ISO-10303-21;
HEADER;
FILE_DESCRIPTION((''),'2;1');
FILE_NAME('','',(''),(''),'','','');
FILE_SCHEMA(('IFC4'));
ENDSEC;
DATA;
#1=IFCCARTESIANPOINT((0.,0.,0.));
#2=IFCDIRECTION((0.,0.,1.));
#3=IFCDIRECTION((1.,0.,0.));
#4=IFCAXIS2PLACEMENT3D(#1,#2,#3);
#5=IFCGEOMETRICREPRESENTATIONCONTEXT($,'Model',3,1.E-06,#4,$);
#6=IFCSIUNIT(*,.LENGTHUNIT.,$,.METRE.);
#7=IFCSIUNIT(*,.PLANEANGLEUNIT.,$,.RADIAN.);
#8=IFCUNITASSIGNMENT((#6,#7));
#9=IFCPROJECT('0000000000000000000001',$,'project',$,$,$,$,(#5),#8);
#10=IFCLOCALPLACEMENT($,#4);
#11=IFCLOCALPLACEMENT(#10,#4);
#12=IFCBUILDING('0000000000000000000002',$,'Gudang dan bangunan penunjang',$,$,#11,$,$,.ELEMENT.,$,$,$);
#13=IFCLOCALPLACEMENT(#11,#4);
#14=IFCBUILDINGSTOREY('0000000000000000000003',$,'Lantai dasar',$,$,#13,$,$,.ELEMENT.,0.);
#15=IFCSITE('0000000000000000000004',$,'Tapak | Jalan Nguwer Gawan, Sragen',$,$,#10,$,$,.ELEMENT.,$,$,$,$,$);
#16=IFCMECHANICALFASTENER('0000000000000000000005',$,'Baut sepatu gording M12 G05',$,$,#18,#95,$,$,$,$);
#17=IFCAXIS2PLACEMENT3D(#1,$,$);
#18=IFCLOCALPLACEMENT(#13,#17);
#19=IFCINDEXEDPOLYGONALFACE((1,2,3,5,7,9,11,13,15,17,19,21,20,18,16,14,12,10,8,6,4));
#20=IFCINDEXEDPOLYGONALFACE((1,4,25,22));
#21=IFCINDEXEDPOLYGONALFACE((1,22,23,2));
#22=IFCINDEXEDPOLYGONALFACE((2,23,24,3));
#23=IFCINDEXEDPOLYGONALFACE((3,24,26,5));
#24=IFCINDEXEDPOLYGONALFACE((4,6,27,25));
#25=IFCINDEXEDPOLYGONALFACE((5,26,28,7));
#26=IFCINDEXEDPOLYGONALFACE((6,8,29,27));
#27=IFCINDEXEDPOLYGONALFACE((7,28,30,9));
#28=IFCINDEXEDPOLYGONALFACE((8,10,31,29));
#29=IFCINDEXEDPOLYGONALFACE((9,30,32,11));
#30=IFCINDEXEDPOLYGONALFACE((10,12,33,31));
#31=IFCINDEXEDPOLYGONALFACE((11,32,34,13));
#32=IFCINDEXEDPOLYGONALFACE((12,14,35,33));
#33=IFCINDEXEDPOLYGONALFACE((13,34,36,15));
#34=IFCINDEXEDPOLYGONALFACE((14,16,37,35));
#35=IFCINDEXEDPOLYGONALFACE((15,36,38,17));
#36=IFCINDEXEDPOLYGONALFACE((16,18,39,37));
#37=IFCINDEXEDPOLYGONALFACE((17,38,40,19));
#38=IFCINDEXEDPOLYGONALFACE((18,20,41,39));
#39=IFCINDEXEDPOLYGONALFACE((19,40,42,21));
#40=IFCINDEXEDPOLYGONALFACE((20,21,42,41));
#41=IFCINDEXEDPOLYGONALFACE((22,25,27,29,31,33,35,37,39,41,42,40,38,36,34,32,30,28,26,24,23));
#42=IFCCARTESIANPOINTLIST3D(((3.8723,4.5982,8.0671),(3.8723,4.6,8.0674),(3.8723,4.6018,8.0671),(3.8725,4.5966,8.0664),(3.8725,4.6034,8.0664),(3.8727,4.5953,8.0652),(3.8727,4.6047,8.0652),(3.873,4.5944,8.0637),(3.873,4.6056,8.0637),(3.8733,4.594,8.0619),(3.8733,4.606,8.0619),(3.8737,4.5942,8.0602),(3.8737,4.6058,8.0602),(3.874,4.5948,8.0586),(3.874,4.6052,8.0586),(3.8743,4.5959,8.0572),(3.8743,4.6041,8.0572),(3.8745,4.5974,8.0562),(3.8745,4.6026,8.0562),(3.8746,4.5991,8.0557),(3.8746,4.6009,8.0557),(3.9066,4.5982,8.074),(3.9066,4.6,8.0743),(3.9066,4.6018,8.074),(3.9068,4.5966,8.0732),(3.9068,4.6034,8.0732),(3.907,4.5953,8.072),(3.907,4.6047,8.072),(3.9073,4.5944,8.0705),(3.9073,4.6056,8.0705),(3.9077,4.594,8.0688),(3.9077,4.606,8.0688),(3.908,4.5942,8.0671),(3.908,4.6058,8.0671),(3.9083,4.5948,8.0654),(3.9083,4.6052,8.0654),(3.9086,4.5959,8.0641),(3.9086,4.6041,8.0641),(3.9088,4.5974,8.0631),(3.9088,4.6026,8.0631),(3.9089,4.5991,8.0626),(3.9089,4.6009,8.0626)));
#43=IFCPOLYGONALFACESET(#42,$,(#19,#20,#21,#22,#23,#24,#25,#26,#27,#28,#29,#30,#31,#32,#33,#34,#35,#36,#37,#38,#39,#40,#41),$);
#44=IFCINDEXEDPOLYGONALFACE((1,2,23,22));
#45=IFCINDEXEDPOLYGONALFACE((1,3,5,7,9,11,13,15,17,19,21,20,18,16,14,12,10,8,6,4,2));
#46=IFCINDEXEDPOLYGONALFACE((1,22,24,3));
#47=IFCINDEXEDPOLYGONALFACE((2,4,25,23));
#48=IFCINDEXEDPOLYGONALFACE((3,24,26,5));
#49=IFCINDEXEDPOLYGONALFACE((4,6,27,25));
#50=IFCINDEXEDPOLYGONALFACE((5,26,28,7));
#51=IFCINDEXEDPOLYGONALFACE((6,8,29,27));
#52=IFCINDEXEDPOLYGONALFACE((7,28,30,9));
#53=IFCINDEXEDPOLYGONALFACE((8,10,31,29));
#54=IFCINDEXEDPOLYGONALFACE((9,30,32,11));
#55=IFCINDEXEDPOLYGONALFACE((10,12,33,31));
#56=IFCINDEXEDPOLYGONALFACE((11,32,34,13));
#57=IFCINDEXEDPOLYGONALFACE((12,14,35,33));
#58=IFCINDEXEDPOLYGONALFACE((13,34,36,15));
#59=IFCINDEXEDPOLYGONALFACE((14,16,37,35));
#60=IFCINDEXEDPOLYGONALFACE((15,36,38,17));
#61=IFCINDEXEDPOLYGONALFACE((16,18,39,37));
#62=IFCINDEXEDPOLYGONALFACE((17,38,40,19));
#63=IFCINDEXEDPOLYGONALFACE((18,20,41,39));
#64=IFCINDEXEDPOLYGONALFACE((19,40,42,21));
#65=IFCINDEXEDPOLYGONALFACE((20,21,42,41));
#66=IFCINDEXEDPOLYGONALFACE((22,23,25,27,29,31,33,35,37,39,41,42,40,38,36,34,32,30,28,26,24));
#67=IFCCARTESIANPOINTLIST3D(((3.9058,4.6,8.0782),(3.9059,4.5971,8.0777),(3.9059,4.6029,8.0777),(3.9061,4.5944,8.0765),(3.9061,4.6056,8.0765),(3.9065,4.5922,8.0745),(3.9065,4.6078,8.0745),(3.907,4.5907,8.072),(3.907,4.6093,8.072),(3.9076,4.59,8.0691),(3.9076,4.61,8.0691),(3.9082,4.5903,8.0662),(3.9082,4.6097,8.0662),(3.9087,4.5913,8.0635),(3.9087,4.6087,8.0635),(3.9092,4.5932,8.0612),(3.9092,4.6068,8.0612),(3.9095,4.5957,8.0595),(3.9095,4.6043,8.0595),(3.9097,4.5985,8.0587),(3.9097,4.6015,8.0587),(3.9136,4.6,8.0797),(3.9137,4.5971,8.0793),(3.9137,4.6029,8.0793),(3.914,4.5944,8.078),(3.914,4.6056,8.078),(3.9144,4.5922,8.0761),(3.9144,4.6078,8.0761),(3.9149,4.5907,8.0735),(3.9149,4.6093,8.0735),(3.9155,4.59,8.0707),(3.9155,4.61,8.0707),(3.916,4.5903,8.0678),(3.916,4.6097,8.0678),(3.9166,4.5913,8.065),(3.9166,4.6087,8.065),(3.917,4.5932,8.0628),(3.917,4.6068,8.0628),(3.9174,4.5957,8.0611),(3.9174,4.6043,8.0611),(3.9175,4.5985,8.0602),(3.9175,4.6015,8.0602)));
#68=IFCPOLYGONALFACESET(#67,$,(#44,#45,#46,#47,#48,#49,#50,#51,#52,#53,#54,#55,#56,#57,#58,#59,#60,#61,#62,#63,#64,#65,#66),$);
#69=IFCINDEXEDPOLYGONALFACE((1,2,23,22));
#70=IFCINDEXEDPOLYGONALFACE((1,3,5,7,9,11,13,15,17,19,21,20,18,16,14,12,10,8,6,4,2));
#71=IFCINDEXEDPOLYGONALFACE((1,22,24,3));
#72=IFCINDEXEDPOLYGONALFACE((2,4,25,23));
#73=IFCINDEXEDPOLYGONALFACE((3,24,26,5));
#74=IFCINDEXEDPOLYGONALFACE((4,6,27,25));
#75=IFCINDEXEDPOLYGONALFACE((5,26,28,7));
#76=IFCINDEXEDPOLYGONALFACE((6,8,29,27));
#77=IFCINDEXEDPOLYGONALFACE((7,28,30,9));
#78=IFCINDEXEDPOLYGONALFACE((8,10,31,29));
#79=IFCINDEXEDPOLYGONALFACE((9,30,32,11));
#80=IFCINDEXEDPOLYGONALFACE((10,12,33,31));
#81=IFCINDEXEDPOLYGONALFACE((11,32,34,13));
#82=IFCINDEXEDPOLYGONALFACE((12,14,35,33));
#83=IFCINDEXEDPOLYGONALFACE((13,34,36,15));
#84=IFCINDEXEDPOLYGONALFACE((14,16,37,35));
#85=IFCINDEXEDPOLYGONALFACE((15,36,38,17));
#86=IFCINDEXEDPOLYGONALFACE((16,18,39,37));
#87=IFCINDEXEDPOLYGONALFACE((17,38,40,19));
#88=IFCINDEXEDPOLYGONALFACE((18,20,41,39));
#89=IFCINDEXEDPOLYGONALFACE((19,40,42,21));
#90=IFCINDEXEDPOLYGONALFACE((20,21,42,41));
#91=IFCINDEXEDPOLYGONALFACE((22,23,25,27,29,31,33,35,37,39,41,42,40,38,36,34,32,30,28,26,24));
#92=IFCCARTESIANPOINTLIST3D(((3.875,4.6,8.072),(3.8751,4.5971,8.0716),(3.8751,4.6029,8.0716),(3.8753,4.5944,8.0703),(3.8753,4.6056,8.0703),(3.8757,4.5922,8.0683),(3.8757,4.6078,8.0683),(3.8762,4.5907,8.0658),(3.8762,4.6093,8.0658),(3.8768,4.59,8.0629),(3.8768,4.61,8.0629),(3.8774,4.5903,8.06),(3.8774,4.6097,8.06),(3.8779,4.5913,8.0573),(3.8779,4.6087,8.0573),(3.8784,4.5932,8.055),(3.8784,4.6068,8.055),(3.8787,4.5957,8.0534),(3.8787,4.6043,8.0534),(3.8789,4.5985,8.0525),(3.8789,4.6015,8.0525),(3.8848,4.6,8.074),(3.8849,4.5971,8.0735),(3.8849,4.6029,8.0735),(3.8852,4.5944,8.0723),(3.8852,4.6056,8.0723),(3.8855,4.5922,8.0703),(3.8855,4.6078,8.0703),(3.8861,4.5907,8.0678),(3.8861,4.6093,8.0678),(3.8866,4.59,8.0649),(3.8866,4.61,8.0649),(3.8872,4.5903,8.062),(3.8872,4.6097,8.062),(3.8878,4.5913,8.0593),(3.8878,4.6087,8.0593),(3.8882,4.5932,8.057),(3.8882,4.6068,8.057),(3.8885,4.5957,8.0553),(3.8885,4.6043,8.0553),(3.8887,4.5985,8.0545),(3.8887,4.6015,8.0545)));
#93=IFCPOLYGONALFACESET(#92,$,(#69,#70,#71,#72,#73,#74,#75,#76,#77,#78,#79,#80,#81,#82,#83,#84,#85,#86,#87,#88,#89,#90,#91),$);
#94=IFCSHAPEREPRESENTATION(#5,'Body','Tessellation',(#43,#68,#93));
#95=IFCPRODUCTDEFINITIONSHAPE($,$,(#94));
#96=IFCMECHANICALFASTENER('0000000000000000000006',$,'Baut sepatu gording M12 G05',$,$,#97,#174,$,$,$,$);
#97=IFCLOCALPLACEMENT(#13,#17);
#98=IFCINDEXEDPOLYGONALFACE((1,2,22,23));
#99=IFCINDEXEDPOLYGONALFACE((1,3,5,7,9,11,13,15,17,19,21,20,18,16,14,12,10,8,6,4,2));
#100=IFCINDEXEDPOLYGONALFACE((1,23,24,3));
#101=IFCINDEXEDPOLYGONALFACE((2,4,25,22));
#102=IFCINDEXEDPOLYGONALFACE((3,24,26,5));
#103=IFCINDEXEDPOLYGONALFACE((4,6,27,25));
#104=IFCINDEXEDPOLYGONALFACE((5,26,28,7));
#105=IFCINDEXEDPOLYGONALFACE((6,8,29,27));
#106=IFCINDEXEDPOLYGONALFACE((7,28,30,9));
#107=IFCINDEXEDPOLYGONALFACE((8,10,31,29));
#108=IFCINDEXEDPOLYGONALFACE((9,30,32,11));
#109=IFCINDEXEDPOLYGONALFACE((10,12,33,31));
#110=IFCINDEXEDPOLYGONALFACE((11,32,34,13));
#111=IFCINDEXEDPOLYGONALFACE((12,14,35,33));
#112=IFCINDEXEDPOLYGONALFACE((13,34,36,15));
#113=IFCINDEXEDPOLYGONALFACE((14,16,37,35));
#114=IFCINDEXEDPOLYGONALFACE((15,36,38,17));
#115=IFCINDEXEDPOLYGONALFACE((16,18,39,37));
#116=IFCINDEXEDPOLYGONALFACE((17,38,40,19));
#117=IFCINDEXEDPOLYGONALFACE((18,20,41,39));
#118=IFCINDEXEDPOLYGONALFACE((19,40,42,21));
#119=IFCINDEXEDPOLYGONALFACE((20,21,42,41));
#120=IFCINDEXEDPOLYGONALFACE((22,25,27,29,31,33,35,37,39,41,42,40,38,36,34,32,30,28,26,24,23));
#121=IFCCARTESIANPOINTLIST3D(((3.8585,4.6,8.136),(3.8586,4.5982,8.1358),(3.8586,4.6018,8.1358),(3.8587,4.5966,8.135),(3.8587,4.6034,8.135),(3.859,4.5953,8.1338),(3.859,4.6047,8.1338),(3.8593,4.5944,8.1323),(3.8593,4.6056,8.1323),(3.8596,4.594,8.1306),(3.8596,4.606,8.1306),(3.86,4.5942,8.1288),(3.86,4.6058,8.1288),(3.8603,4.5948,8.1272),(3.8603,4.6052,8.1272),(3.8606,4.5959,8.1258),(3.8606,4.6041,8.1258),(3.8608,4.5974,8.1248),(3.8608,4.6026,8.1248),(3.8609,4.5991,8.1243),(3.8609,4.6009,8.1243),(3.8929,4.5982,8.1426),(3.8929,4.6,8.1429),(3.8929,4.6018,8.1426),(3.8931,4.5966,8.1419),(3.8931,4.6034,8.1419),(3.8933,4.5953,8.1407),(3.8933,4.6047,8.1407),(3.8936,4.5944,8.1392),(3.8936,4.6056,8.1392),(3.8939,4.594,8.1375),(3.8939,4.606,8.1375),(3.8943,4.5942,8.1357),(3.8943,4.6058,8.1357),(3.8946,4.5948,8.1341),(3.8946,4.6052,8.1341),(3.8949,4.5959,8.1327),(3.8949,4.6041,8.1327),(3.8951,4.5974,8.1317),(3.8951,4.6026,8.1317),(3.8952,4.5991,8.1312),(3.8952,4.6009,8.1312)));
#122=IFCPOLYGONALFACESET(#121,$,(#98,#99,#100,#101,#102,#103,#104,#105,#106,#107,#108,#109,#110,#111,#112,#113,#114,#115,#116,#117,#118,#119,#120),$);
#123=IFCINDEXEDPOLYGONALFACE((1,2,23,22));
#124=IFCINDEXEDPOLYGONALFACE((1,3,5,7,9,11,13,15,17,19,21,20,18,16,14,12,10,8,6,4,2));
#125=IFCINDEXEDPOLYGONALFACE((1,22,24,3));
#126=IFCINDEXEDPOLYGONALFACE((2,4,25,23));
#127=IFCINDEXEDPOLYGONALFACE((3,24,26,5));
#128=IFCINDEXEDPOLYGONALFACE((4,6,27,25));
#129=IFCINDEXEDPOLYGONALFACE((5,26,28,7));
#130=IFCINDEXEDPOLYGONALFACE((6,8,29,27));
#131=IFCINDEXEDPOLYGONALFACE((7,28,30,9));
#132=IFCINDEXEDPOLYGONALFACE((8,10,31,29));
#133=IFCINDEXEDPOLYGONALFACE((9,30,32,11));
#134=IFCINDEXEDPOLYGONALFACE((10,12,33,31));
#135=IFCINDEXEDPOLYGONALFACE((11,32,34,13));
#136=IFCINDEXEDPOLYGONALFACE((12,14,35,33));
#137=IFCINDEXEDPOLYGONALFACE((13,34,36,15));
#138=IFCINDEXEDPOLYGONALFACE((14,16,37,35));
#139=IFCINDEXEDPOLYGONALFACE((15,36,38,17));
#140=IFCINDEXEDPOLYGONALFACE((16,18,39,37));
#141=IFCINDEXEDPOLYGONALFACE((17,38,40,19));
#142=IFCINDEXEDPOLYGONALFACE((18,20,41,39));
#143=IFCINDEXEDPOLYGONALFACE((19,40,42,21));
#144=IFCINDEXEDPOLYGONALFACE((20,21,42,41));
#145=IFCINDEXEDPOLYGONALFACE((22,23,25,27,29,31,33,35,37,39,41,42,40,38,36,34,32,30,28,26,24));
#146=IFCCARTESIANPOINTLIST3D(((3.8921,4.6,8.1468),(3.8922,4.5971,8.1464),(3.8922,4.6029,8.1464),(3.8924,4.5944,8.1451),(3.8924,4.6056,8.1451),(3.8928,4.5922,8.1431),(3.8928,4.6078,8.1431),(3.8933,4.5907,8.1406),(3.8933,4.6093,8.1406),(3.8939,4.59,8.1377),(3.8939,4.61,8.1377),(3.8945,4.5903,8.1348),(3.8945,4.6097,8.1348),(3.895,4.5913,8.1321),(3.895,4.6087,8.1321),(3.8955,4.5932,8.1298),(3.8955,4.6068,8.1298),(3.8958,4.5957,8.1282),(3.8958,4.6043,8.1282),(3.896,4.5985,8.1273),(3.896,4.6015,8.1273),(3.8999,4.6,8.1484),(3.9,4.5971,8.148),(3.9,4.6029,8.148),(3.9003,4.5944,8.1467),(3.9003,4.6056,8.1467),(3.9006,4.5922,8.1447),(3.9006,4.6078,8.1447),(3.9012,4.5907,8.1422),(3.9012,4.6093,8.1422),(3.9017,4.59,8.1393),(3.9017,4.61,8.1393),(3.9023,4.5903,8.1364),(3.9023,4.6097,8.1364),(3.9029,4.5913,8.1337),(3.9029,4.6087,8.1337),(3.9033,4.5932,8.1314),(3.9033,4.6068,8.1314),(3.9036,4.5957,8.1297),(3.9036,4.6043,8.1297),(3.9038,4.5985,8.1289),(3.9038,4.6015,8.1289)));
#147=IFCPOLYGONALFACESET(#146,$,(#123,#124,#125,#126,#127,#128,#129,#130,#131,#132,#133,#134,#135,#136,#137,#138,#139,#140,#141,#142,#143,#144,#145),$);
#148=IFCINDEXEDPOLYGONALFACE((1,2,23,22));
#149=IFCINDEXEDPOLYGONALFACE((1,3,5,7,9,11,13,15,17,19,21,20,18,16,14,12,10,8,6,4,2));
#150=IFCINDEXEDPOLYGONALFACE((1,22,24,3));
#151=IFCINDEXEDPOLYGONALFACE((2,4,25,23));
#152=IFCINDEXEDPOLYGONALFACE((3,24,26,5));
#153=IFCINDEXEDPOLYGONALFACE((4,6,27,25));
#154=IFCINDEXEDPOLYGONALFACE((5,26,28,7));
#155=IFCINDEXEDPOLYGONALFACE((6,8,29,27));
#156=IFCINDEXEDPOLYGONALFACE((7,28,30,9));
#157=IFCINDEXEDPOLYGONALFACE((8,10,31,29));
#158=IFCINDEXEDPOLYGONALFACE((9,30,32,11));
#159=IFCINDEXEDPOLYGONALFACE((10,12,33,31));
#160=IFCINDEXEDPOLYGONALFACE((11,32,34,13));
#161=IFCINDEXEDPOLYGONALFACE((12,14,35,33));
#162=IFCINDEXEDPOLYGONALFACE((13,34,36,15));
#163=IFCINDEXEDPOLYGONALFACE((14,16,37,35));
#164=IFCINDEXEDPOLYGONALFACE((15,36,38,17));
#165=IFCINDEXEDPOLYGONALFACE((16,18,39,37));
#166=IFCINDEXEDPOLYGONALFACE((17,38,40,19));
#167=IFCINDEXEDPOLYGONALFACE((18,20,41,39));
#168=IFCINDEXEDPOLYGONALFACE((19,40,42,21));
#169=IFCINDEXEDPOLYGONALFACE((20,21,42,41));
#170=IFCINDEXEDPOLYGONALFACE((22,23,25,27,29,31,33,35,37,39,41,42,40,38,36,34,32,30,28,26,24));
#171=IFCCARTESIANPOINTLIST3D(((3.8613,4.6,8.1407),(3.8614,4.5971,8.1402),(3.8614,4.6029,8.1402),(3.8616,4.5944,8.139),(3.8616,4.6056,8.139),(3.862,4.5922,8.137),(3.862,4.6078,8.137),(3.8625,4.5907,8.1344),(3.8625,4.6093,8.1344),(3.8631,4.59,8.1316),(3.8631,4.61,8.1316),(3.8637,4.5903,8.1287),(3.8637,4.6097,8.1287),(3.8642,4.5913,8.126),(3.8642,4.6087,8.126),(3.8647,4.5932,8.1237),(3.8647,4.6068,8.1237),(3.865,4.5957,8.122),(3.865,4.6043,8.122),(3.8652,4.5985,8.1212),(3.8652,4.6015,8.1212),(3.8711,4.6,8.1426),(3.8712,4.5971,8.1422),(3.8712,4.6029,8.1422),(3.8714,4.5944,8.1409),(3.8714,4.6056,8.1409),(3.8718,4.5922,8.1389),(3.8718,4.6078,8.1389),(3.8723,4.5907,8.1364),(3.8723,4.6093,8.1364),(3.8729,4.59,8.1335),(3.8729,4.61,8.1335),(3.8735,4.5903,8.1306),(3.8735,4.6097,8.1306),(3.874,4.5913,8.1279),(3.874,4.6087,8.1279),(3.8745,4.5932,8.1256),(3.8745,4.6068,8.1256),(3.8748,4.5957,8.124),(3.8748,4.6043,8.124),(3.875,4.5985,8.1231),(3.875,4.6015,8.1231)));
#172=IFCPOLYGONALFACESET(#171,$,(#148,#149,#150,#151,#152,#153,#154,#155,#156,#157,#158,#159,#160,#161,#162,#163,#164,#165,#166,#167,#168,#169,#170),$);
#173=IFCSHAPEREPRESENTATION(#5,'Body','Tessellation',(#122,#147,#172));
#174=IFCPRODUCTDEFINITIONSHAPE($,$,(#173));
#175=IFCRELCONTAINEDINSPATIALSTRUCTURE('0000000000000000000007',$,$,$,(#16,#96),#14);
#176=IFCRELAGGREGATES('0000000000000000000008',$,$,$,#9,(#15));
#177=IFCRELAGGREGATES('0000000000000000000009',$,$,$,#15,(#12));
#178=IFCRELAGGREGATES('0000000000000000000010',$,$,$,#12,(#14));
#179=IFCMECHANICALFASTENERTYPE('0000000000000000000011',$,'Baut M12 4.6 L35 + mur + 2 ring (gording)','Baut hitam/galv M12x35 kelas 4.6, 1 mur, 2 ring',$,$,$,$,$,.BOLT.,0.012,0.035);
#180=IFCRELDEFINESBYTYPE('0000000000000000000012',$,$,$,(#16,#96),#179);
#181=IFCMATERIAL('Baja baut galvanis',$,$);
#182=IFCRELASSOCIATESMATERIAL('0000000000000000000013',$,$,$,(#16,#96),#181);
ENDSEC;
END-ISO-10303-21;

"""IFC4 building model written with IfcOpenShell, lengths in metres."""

from ifc_helpers import new_model, si_unit, frame, origin_with_axes, place, context, project, spatial, circle, extrude, source, transform, mapped, material, type_object, type_shapes, element, save


model = new_model("IFC4")

# Units and contexts
model_context = context("Model", 3, precision=1e-06, world=origin_with_axes())
ifc_project = project(units=[si_unit("LENGTHUNIT", "METRE"), si_unit("PLANEANGLEUNIT", "RADIAN")], contexts=[model_context])

# Site, building, storey
site_placement = place(None, origin_with_axes())
site = spatial("IfcSite", under=ifc_project, at=site_placement, Name="Tapak | Jalan Nguwer Gawan, Sragen", CompositionType="ELEMENT")
building_placement = place(site_placement, origin_with_axes())
building = spatial("IfcBuilding", under=site, at=building_placement, Name="Gudang dan bangunan penunjang", CompositionType="ELEMENT")
storey_placement = place(building_placement, origin_with_axes())
storey = spatial("IfcBuildingStorey", under=building, at=storey_placement, Name="Lantai dasar", CompositionType="ELEMENT", Elevation=0.0)

# Shared definitions
placement = place(None, origin_with_axes())

# Mechanical fasteners
ifc_material_1 = material(Name="Baja baut galvanis")
mechanical_fastener_type = type_object("IfcMechanicalFastenerType", Name="Baut M12 4.6 L35 + mur + 2 ring (gording)", Description="Baut hitam/galv M12x35 kelas 4.6, 1 mur, 2 ring", NominalDiameter=0.012, NominalLength=0.035, PredefinedType="BOLT")
shared_shape = source(origin_with_axes(), model_context, "Body", "SweptSolid", [
    extrude(circle(Radius=0.006), origin_with_axes(), (0.0, 0.0, 1.0), 0.035),
    extrude(circle(Radius=0.01), frame((0.0, 0.0, -0.008), z_axis=(0.0, 0.0, 1.0), x_axis=(1.0, 0.0, 0.0)), (0.0, 0.0, 1.0), 0.008),
    extrude(circle(Radius=0.01), frame((0.0, 0.0, 0.0214), z_axis=(0.0, 0.0, 1.0), x_axis=(1.0, 0.0, 0.0)), (0.0, 0.0, 1.0), 0.01),
])
type_shapes(mechanical_fastener_type, [shared_shape])
element("IfcMechanicalFastener", 1, at=placement, inside=storey, type_object=mechanical_fastener_type, material=ifc_material_1, Name="Baut sepatu gording M12 G05", context=model_context, shape_type="MappedRepresentation", body=[
    mapped(shared_shape, transform((3.9078, 4.6, 8.0684), x_axis=(-0.196116, 0.0, 0.980581), y_axis=(0.0, 1.0, 0.0), z_axis=(-0.980581, 0.0, -0.196116), scale=1.0)),
])
element("IfcMechanicalFastener", 2, at=placement, inside=storey, type_object=mechanical_fastener_type, material=ifc_material_1, Name="Baut sepatu gording M12 G05", context=model_context, shape_type="MappedRepresentation", body=[
    mapped(shared_shape, transform((3.894, 4.6, 8.137), x_axis=(-0.196116, 0.0, 0.980581), y_axis=(0.0, 1.0, 0.0), z_axis=(-0.980581, 0.0, -0.196116), scale=1.0)),
])

save(model, "model.ifc")
